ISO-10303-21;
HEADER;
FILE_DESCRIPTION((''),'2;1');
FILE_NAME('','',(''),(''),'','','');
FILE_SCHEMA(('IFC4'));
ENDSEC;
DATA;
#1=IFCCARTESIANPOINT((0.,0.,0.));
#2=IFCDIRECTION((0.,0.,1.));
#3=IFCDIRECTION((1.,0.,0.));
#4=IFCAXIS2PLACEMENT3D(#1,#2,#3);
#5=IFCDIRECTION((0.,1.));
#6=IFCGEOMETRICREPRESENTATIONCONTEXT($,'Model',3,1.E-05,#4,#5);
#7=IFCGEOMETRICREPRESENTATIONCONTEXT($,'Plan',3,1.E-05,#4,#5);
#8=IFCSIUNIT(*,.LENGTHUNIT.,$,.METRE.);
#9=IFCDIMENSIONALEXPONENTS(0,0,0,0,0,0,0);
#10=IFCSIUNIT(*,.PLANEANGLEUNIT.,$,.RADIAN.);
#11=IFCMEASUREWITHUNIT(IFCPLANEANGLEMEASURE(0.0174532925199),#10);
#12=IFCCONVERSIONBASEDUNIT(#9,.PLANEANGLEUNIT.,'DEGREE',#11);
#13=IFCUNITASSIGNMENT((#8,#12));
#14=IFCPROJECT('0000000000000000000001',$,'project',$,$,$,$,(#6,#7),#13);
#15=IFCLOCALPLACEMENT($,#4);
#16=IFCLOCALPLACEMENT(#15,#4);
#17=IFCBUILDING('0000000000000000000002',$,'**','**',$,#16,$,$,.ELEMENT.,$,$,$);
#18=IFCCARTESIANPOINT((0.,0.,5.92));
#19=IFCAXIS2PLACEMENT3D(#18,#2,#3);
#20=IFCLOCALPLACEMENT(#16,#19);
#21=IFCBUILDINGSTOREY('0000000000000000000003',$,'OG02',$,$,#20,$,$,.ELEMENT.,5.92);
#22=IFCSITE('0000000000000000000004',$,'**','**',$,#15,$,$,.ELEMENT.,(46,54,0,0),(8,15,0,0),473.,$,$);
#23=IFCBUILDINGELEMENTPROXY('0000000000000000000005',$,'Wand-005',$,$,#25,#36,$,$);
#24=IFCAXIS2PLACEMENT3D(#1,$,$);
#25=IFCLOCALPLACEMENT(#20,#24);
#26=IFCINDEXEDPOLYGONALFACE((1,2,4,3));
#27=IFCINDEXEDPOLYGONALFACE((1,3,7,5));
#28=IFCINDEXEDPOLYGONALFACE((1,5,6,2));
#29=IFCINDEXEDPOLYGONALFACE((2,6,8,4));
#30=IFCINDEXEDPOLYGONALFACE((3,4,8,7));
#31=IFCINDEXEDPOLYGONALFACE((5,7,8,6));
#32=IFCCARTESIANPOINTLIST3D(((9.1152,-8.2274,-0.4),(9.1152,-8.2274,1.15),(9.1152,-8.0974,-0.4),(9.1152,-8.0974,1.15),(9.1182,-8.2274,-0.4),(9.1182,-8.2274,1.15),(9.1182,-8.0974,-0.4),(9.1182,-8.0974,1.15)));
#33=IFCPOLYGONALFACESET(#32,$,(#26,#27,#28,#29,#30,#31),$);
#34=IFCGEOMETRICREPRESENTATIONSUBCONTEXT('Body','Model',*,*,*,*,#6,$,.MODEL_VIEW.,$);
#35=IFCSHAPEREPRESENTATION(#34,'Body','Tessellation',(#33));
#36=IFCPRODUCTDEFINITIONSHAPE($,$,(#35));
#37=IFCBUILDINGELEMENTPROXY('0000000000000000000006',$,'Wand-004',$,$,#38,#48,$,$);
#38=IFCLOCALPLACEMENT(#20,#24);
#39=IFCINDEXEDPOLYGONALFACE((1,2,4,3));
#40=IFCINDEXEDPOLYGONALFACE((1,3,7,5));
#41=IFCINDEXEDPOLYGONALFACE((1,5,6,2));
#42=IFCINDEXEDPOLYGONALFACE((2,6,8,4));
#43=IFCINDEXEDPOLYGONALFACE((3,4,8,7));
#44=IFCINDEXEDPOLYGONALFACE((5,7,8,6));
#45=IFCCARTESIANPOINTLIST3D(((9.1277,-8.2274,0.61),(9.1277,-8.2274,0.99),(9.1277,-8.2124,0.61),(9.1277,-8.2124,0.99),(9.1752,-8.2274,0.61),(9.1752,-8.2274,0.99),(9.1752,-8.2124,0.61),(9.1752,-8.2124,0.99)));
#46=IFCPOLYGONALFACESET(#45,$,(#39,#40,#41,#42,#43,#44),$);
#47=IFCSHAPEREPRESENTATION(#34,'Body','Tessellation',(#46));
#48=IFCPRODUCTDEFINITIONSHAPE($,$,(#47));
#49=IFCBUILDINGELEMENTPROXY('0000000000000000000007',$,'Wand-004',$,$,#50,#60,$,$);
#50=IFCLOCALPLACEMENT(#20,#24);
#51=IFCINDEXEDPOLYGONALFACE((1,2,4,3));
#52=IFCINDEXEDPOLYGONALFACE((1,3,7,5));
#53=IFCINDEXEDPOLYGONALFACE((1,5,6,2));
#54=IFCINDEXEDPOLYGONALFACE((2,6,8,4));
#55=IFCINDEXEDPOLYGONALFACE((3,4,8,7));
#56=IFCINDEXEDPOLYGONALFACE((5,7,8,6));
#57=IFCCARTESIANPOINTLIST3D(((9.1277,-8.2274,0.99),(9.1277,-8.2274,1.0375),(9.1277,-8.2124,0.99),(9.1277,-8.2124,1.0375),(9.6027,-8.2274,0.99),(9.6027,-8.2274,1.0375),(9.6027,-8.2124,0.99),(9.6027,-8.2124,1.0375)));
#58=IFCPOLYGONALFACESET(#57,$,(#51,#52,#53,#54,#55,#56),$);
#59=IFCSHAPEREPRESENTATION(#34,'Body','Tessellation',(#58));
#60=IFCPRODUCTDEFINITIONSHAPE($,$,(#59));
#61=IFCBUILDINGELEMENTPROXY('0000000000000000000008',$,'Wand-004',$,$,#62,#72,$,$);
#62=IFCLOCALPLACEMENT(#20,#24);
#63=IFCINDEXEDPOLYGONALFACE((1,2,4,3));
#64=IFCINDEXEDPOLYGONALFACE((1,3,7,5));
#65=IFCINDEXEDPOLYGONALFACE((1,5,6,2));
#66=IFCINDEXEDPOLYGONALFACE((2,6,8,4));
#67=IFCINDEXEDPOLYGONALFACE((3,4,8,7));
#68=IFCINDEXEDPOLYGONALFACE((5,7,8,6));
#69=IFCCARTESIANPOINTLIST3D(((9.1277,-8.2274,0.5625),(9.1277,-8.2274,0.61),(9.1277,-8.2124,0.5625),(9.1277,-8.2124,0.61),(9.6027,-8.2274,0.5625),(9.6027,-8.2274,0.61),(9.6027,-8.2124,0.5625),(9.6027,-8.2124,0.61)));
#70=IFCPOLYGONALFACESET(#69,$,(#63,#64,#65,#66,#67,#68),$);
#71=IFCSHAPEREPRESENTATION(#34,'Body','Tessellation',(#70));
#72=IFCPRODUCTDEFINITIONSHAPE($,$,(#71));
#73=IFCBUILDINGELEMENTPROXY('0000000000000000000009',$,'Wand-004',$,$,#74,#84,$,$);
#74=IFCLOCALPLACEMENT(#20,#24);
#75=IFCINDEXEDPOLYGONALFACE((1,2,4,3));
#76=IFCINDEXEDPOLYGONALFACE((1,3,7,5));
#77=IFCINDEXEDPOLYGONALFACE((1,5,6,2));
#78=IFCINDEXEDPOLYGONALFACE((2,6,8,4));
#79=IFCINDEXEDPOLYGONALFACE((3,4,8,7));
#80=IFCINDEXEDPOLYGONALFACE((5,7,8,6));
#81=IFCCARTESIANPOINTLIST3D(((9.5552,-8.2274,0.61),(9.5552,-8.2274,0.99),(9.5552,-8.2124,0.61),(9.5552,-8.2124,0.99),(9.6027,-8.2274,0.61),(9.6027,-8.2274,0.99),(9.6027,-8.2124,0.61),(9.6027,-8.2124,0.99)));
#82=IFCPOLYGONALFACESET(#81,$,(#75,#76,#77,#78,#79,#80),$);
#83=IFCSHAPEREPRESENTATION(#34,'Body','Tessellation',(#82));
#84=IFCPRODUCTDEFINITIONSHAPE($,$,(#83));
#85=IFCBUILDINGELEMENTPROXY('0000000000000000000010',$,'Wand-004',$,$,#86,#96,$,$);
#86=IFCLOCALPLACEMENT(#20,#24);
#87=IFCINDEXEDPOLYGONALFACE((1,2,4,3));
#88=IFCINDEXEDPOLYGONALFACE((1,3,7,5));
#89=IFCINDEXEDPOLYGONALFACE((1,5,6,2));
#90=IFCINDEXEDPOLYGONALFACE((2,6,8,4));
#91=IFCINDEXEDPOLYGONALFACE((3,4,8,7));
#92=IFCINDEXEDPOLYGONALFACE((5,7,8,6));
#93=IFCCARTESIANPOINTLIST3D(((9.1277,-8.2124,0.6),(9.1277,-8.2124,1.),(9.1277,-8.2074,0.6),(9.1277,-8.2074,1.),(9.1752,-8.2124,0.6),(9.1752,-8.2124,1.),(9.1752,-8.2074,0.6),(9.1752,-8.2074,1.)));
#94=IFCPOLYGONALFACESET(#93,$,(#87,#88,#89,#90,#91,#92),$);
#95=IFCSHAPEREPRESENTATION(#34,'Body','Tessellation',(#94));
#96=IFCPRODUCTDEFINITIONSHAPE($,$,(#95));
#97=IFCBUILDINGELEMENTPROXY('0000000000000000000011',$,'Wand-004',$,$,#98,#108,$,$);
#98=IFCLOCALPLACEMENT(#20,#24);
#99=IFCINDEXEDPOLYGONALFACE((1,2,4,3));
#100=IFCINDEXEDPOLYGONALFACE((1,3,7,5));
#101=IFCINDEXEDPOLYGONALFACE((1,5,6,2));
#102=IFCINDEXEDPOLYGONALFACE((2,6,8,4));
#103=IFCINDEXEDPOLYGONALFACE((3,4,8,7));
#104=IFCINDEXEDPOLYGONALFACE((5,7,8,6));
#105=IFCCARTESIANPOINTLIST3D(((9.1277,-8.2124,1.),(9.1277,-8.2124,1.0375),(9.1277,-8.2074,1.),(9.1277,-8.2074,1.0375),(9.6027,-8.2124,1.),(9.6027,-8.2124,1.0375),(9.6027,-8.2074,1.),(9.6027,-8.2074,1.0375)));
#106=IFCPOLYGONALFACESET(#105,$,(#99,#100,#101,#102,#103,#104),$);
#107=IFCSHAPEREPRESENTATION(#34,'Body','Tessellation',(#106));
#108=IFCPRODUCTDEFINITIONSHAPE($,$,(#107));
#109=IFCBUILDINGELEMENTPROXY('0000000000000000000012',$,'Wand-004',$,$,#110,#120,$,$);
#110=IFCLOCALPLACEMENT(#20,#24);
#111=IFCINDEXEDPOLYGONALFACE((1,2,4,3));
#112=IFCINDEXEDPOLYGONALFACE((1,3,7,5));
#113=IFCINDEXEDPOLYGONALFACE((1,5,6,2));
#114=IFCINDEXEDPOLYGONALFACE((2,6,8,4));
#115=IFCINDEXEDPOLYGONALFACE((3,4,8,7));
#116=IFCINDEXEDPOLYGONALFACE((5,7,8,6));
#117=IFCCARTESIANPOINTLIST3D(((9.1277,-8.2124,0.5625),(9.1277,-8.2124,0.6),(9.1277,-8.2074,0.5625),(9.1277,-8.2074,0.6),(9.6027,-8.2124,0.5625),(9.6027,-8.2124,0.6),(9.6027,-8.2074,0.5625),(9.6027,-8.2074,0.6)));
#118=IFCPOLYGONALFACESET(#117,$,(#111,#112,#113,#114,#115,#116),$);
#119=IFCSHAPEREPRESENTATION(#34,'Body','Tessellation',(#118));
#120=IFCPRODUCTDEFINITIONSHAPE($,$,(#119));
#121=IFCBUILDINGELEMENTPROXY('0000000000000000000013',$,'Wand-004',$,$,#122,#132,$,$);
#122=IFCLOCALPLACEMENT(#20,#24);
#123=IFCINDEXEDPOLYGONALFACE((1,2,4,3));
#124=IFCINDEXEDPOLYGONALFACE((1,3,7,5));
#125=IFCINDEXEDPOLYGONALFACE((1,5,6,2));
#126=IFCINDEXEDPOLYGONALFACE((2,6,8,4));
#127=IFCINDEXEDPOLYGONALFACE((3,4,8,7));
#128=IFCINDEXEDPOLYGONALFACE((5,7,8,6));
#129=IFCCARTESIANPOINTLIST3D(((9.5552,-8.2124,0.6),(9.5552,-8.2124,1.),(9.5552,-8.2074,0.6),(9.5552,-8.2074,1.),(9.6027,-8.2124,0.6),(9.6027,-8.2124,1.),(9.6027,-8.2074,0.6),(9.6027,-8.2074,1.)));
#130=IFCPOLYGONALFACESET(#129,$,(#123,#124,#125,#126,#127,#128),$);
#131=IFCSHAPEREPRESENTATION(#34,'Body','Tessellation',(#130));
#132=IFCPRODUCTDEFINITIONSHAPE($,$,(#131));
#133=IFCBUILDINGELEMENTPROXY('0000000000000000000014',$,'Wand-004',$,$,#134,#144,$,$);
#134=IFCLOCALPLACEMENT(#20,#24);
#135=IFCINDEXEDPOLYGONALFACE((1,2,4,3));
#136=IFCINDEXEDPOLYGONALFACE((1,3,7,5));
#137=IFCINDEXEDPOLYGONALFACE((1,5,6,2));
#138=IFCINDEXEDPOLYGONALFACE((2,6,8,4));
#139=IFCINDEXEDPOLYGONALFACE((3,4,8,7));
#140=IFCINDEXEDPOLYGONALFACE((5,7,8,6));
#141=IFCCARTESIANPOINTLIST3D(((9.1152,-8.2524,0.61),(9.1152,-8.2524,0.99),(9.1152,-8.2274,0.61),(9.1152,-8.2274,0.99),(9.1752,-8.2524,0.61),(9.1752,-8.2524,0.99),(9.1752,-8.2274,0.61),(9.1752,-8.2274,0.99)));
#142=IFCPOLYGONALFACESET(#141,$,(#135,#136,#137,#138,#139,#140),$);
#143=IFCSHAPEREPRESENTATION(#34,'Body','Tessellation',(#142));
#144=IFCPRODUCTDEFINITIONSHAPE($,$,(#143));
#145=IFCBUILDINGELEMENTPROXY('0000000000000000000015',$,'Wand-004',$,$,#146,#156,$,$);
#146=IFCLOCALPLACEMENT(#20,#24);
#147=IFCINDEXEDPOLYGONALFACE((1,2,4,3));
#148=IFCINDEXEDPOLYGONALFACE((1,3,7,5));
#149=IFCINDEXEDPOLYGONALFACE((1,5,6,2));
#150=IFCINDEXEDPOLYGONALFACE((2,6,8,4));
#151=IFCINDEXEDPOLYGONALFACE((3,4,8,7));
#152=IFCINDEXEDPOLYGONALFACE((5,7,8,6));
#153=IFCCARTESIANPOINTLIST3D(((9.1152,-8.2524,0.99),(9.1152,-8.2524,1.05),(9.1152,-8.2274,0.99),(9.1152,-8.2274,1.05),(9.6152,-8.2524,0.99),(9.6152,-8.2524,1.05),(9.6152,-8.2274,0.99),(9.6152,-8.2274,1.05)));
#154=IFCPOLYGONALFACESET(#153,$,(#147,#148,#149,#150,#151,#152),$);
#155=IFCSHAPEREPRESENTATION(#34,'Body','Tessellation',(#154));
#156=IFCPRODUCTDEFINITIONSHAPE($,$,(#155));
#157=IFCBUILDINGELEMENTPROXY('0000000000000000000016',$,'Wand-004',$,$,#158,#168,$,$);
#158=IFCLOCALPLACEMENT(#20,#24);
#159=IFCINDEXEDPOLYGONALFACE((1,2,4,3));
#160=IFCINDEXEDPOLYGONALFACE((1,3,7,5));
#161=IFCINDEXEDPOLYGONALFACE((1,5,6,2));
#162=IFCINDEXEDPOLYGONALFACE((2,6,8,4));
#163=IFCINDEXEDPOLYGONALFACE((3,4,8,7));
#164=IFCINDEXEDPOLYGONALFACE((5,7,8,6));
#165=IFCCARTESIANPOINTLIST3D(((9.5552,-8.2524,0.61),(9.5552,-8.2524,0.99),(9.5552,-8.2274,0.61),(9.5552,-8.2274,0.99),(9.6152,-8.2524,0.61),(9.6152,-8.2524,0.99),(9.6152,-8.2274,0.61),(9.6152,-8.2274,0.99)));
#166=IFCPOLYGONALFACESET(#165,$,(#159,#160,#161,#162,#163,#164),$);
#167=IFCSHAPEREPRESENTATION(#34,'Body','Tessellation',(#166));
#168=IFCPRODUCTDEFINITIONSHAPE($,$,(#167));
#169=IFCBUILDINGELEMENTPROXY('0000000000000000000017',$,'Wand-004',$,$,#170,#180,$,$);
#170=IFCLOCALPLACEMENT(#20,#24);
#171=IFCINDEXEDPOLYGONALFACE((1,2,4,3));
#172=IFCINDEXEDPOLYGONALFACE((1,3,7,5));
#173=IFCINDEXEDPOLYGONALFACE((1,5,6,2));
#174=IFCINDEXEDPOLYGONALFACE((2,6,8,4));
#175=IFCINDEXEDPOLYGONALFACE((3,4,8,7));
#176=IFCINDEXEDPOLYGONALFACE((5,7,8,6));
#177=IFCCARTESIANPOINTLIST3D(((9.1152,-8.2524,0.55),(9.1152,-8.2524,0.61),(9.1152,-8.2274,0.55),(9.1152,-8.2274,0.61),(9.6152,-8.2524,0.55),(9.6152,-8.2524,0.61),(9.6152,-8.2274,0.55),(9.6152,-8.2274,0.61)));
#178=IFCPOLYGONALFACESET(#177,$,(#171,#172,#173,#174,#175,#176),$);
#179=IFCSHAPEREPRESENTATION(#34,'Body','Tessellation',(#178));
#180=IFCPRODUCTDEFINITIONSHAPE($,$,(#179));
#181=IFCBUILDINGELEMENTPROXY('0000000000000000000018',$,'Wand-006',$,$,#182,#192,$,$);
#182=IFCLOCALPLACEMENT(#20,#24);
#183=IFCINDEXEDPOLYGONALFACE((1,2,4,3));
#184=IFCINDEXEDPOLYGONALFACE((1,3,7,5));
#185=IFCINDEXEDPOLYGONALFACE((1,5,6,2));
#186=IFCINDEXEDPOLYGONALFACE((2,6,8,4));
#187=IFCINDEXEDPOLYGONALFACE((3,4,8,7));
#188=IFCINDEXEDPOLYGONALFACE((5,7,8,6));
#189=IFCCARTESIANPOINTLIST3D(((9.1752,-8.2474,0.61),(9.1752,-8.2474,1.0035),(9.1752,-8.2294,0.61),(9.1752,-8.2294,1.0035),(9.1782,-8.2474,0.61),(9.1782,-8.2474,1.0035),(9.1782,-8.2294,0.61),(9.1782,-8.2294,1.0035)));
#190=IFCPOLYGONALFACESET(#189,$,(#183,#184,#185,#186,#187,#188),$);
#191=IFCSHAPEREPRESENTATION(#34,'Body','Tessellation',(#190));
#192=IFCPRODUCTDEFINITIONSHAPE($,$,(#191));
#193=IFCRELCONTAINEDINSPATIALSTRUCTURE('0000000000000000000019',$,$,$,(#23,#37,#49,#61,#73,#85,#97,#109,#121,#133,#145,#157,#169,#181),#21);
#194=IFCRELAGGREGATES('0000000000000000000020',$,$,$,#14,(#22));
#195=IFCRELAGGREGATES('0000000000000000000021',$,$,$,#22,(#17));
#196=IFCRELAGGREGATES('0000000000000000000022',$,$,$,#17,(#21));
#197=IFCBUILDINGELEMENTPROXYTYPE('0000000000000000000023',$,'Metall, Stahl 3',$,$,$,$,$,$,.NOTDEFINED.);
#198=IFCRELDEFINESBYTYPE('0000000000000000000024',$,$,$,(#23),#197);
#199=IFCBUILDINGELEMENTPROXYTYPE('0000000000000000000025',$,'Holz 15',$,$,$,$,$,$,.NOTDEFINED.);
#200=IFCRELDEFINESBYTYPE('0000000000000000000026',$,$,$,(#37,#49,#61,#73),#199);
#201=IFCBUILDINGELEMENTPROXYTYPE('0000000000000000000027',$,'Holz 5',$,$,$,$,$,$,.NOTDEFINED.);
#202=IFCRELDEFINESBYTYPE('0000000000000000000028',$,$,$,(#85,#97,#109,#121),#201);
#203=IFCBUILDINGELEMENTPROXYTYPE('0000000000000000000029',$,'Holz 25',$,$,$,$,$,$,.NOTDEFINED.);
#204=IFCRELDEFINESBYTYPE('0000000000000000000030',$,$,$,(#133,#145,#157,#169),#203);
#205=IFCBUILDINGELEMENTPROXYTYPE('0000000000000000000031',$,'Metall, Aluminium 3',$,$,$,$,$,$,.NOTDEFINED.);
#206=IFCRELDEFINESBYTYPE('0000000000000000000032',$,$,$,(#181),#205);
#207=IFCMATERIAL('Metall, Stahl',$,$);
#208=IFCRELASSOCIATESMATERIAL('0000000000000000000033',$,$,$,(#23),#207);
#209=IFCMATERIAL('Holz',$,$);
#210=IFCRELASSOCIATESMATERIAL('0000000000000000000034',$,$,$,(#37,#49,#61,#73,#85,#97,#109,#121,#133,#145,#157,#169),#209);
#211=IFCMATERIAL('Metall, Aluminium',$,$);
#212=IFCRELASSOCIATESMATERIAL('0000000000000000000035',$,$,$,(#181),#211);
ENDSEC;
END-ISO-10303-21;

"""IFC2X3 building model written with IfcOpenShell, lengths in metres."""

from ifc_helpers import new_model, entity, si_unit, converted_unit, direction, frame, origin_with_axes, place, context, subcontext, project, spatial, polyline, outline, extrude, material, type_object, element, save


model = new_model("IFC2X3")

# Units and contexts
model_context = context("Model", 3, precision=1e-05, world=origin_with_axes(), true_north=direction((0.0, 1.0)))
plan_context = context("Plan", 3, precision=1e-05, world=origin_with_axes(), true_north=direction((0.0, 1.0)))
body_context = subcontext(model_context, "Body", "Model", "MODEL_VIEW")
ifc_project = project(units=[si_unit("LENGTHUNIT", "METRE"), converted_unit("PLANEANGLEUNIT", "DEGREE", entity("IfcPlaneAngleMeasure", 0.0174532925199), si_unit("PLANEANGLEUNIT", "RADIAN"), dimensions=[0, 0, 0, 0, 0, 0, 0])], contexts=[model_context, plan_context])

# Site, building, storey
site_placement = place(None, origin_with_axes())
site = spatial("IfcSite", under=ifc_project, at=site_placement, Name="**", Description="**", CompositionType="ELEMENT", RefLatitude=(46, 54, 0, 0), RefLongitude=(8, 15, 0, 0), RefElevation=473.0)
building_placement = place(site_placement, origin_with_axes())
building = spatial("IfcBuilding", under=site, at=building_placement, Name="**", Description="**", CompositionType="ELEMENT")
storey_placement = place(building_placement, frame((0.0, 0.0, 5.92), z_axis=(0.0, 0.0, 1.0), x_axis=(1.0, 0.0, 0.0)))
storey = spatial("IfcBuildingStorey", under=building, at=storey_placement, Name="OG02", CompositionType="ELEMENT", Elevation=5.92)

# Building element proxies
ifc_material_1 = material(Name="Metall, Stahl")
building_element_proxy_type_1 = type_object("IfcBuildingElementProxyType", Name="Metall, Stahl 3", PredefinedType="NOTDEFINED")
proxy_1_placement = place(storey_placement, frame((9.1152, -8.0974, -0.4), z_axis=(0.0, 0.0, 1.0), x_axis=(0.0, -1.0, 0.0)))
element("IfcBuildingElementProxy", 1, at=proxy_1_placement, inside=storey, type_object=building_element_proxy_type_1, material=ifc_material_1, Name="Wand-005", context=body_context, shape_type="SweptSolid", body=[
    extrude(outline(polyline([(0.0, 0.0), (0.13, 0.0), (0.13, 0.003), (0.0, 0.003), (0.0, 0.0)])), origin_with_axes(), (0.0, 0.0, 1.0), 1.55),
])
ifc_material_2 = material(Name="Holz")
building_element_proxy_type_2 = type_object("IfcBuildingElementProxyType", Name="Holz 15", PredefinedType="NOTDEFINED")
proxy_2_placement = place(storey_placement, frame((9.1277, -8.2274, 0.61), z_axis=(0.0, 0.0, 1.0), x_axis=(1.0, 0.0, 0.0)))
element("IfcBuildingElementProxy", 2, at=proxy_2_placement, inside=storey, type_object=building_element_proxy_type_2, material=ifc_material_2, Name="Wand-004", context=body_context, shape_type="SweptSolid", body=[
    extrude(outline(polyline([(0.0, 0.0), (0.0475, 0.0), (0.0475, 0.015), (0.0, 0.015), (0.0, 0.0)])), origin_with_axes(), (0.0, 0.0, 1.0), 0.38),
])
for number, where, z_axis, x_axis, name in (
    (3, (9.6027, -8.2124, 0.99), (0.0, 0.0, 1.0), (-1.0, 0.0, 0.0), "Wand-004"),
    (4, (9.6027, -8.2124, 0.5625), (0.0, 0.0, 1.0), (-1.0, 0.0, 0.0), "Wand-004"),
):
    element("IfcBuildingElementProxy", number, at=place(storey_placement, frame(where, z_axis=z_axis, x_axis=x_axis)), inside=storey, type_object=building_element_proxy_type_2, material=ifc_material_2, Name=name, context=body_context, shape_type="SweptSolid", body=[
        extrude(outline(polyline([(0.0, 0.0), (0.475, 0.0), (0.475, 0.015), (0.0, 0.015), (0.0, 0.0)])), origin_with_axes(), (0.0, 0.0, 1.0), 0.0475),
    ])
proxy_3_placement = place(storey_placement, frame((9.5552, -8.2274, 0.61), z_axis=(0.0, 0.0, 1.0), x_axis=(1.0, 0.0, 0.0)))
element("IfcBuildingElementProxy", 5, at=proxy_3_placement, inside=storey, type_object=building_element_proxy_type_2, material=ifc_material_2, Name="Wand-004", context=body_context, shape_type="SweptSolid", body=[
    extrude(outline(polyline([(0.0, 0.0), (0.0475, 0.0), (0.0475, 0.015), (0.0, 0.015), (0.0, 0.0)])), origin_with_axes(), (0.0, 0.0, 1.0), 0.38),
])
building_element_proxy_type_3 = type_object("IfcBuildingElementProxyType", Name="Holz 5", PredefinedType="NOTDEFINED")
proxy_4_placement = place(storey_placement, frame((9.1277, -8.2124, 0.6), z_axis=(0.0, 0.0, 1.0), x_axis=(1.0, 0.0, 0.0)))
element("IfcBuildingElementProxy", 6, at=proxy_4_placement, inside=storey, type_object=building_element_proxy_type_3, material=ifc_material_2, Name="Wand-004", context=body_context, shape_type="SweptSolid", body=[
    extrude(outline(polyline([(0.0, 0.0), (0.0475, 0.0), (0.0475, 0.005), (0.0, 0.005), (0.0, 0.0)])), origin_with_axes(), (0.0, 0.0, 1.0), 0.4),
])
for number, where, z_axis, x_axis, name in (
    (7, (9.6027, -8.2124, 1.0), (0.0, 0.0, 1.0), (-1.0, 0.0, 0.0), "Wand-004"),
    (8, (9.6027, -8.2124, 0.5625), (0.0, 0.0, 1.0), (-1.0, 0.0, 0.0), "Wand-004"),
):
    element("IfcBuildingElementProxy", number, at=place(storey_placement, frame(where, z_axis=z_axis, x_axis=x_axis)), inside=storey, type_object=building_element_proxy_type_3, material=ifc_material_2, Name=name, context=body_context, shape_type="SweptSolid", body=[
        extrude(outline(polyline([(0.0, -0.005), (0.475, -0.005), (0.475, 0.0), (0.0, 0.0), (0.0, -0.005)])), origin_with_axes(), (0.0, 0.0, 1.0), 0.0375),
    ])
proxy_5_placement = place(storey_placement, frame((9.5552, -8.2124, 0.6), z_axis=(0.0, 0.0, 1.0), x_axis=(1.0, 0.0, 0.0)))
element("IfcBuildingElementProxy", 9, at=proxy_5_placement, inside=storey, type_object=building_element_proxy_type_3, material=ifc_material_2, Name="Wand-004", context=body_context, shape_type="SweptSolid", body=[
    extrude(outline(polyline([(0.0, 0.0), (0.0475, 0.0), (0.0475, 0.005), (0.0, 0.005), (0.0, 0.0)])), origin_with_axes(), (0.0, 0.0, 1.0), 0.4),
])
building_element_proxy_type_4 = type_object("IfcBuildingElementProxyType", Name="Holz 25", PredefinedType="NOTDEFINED")
proxy_6_placement = place(storey_placement, frame((9.1152, -8.2524, 0.61), z_axis=(0.0, 0.0, 1.0), x_axis=(1.0, 0.0, 0.0)))
element("IfcBuildingElementProxy", 10, at=proxy_6_placement, inside=storey, type_object=building_element_proxy_type_4, material=ifc_material_2, Name="Wand-004", context=body_context, shape_type="SweptSolid", body=[
    extrude(outline(polyline([(0.0, 0.0), (0.06, 0.0), (0.06, 0.025), (0.0, 0.025), (0.0, 0.0)])), origin_with_axes(), (0.0, 0.0, 1.0), 0.38),
])
proxy_7_placement = place(storey_placement, frame((9.6152, -8.2274, 0.99), z_axis=(0.0, 0.0, 1.0), x_axis=(-1.0, 0.0, 0.0)))
element("IfcBuildingElementProxy", 11, at=proxy_7_placement, inside=storey, type_object=building_element_proxy_type_4, material=ifc_material_2, Name="Wand-004", context=body_context, shape_type="SweptSolid", body=[
    extrude(outline(polyline([(0.0, 0.0), (0.5, 0.0), (0.5, 0.025), (0.0, 0.025), (0.0, 0.0)])), origin_with_axes(), (0.0, 0.0, 1.0), 0.06),
])
proxy_8_placement = place(storey_placement, frame((9.5552, -8.2524, 0.61), z_axis=(0.0, 0.0, 1.0), x_axis=(1.0, 0.0, 0.0)))
element("IfcBuildingElementProxy", 12, at=proxy_8_placement, inside=storey, type_object=building_element_proxy_type_4, material=ifc_material_2, Name="Wand-004", context=body_context, shape_type="SweptSolid", body=[
    extrude(outline(polyline([(0.0, 0.0), (0.06, 0.0), (0.06, 0.025), (0.0, 0.025), (0.0, 0.0)])), origin_with_axes(), (0.0, 0.0, 1.0), 0.38),
])
proxy_9_placement = place(storey_placement, frame((9.6152, -8.2274, 0.55), z_axis=(0.0, 0.0, 1.0), x_axis=(-1.0, 0.0, 0.0)))
element("IfcBuildingElementProxy", 13, at=proxy_9_placement, inside=storey, type_object=building_element_proxy_type_4, material=ifc_material_2, Name="Wand-004", context=body_context, shape_type="SweptSolid", body=[
    extrude(outline(polyline([(0.0, 0.0), (0.5, 0.0), (0.5, 0.025), (0.0, 0.025), (0.0, 0.0)])), origin_with_axes(), (0.0, 0.0, 1.0), 0.06),
])
ifc_material_3 = material(Name="Metall, Aluminium")
building_element_proxy_type_5 = type_object("IfcBuildingElementProxyType", Name="Metall, Aluminium 3", PredefinedType="NOTDEFINED")
proxy_10_placement = place(storey_placement, frame((9.1752, -8.2294, 0.61), z_axis=(0.0, 0.0, 1.0), x_axis=(0.0, -1.0, 0.0)))
element("IfcBuildingElementProxy", 14, at=proxy_10_placement, inside=storey, type_object=building_element_proxy_type_5, material=ifc_material_3, Name="Wand-006", context=body_context, shape_type="SweptSolid", body=[
    extrude(outline(polyline([(0.0, 0.0), (0.018, 0.0), (0.018, 0.003), (0.0, 0.003), (0.0, 0.0)])), origin_with_axes(), (0.0, 0.0, 1.0), 0.3935),
])

save(model, "model.ifc")
